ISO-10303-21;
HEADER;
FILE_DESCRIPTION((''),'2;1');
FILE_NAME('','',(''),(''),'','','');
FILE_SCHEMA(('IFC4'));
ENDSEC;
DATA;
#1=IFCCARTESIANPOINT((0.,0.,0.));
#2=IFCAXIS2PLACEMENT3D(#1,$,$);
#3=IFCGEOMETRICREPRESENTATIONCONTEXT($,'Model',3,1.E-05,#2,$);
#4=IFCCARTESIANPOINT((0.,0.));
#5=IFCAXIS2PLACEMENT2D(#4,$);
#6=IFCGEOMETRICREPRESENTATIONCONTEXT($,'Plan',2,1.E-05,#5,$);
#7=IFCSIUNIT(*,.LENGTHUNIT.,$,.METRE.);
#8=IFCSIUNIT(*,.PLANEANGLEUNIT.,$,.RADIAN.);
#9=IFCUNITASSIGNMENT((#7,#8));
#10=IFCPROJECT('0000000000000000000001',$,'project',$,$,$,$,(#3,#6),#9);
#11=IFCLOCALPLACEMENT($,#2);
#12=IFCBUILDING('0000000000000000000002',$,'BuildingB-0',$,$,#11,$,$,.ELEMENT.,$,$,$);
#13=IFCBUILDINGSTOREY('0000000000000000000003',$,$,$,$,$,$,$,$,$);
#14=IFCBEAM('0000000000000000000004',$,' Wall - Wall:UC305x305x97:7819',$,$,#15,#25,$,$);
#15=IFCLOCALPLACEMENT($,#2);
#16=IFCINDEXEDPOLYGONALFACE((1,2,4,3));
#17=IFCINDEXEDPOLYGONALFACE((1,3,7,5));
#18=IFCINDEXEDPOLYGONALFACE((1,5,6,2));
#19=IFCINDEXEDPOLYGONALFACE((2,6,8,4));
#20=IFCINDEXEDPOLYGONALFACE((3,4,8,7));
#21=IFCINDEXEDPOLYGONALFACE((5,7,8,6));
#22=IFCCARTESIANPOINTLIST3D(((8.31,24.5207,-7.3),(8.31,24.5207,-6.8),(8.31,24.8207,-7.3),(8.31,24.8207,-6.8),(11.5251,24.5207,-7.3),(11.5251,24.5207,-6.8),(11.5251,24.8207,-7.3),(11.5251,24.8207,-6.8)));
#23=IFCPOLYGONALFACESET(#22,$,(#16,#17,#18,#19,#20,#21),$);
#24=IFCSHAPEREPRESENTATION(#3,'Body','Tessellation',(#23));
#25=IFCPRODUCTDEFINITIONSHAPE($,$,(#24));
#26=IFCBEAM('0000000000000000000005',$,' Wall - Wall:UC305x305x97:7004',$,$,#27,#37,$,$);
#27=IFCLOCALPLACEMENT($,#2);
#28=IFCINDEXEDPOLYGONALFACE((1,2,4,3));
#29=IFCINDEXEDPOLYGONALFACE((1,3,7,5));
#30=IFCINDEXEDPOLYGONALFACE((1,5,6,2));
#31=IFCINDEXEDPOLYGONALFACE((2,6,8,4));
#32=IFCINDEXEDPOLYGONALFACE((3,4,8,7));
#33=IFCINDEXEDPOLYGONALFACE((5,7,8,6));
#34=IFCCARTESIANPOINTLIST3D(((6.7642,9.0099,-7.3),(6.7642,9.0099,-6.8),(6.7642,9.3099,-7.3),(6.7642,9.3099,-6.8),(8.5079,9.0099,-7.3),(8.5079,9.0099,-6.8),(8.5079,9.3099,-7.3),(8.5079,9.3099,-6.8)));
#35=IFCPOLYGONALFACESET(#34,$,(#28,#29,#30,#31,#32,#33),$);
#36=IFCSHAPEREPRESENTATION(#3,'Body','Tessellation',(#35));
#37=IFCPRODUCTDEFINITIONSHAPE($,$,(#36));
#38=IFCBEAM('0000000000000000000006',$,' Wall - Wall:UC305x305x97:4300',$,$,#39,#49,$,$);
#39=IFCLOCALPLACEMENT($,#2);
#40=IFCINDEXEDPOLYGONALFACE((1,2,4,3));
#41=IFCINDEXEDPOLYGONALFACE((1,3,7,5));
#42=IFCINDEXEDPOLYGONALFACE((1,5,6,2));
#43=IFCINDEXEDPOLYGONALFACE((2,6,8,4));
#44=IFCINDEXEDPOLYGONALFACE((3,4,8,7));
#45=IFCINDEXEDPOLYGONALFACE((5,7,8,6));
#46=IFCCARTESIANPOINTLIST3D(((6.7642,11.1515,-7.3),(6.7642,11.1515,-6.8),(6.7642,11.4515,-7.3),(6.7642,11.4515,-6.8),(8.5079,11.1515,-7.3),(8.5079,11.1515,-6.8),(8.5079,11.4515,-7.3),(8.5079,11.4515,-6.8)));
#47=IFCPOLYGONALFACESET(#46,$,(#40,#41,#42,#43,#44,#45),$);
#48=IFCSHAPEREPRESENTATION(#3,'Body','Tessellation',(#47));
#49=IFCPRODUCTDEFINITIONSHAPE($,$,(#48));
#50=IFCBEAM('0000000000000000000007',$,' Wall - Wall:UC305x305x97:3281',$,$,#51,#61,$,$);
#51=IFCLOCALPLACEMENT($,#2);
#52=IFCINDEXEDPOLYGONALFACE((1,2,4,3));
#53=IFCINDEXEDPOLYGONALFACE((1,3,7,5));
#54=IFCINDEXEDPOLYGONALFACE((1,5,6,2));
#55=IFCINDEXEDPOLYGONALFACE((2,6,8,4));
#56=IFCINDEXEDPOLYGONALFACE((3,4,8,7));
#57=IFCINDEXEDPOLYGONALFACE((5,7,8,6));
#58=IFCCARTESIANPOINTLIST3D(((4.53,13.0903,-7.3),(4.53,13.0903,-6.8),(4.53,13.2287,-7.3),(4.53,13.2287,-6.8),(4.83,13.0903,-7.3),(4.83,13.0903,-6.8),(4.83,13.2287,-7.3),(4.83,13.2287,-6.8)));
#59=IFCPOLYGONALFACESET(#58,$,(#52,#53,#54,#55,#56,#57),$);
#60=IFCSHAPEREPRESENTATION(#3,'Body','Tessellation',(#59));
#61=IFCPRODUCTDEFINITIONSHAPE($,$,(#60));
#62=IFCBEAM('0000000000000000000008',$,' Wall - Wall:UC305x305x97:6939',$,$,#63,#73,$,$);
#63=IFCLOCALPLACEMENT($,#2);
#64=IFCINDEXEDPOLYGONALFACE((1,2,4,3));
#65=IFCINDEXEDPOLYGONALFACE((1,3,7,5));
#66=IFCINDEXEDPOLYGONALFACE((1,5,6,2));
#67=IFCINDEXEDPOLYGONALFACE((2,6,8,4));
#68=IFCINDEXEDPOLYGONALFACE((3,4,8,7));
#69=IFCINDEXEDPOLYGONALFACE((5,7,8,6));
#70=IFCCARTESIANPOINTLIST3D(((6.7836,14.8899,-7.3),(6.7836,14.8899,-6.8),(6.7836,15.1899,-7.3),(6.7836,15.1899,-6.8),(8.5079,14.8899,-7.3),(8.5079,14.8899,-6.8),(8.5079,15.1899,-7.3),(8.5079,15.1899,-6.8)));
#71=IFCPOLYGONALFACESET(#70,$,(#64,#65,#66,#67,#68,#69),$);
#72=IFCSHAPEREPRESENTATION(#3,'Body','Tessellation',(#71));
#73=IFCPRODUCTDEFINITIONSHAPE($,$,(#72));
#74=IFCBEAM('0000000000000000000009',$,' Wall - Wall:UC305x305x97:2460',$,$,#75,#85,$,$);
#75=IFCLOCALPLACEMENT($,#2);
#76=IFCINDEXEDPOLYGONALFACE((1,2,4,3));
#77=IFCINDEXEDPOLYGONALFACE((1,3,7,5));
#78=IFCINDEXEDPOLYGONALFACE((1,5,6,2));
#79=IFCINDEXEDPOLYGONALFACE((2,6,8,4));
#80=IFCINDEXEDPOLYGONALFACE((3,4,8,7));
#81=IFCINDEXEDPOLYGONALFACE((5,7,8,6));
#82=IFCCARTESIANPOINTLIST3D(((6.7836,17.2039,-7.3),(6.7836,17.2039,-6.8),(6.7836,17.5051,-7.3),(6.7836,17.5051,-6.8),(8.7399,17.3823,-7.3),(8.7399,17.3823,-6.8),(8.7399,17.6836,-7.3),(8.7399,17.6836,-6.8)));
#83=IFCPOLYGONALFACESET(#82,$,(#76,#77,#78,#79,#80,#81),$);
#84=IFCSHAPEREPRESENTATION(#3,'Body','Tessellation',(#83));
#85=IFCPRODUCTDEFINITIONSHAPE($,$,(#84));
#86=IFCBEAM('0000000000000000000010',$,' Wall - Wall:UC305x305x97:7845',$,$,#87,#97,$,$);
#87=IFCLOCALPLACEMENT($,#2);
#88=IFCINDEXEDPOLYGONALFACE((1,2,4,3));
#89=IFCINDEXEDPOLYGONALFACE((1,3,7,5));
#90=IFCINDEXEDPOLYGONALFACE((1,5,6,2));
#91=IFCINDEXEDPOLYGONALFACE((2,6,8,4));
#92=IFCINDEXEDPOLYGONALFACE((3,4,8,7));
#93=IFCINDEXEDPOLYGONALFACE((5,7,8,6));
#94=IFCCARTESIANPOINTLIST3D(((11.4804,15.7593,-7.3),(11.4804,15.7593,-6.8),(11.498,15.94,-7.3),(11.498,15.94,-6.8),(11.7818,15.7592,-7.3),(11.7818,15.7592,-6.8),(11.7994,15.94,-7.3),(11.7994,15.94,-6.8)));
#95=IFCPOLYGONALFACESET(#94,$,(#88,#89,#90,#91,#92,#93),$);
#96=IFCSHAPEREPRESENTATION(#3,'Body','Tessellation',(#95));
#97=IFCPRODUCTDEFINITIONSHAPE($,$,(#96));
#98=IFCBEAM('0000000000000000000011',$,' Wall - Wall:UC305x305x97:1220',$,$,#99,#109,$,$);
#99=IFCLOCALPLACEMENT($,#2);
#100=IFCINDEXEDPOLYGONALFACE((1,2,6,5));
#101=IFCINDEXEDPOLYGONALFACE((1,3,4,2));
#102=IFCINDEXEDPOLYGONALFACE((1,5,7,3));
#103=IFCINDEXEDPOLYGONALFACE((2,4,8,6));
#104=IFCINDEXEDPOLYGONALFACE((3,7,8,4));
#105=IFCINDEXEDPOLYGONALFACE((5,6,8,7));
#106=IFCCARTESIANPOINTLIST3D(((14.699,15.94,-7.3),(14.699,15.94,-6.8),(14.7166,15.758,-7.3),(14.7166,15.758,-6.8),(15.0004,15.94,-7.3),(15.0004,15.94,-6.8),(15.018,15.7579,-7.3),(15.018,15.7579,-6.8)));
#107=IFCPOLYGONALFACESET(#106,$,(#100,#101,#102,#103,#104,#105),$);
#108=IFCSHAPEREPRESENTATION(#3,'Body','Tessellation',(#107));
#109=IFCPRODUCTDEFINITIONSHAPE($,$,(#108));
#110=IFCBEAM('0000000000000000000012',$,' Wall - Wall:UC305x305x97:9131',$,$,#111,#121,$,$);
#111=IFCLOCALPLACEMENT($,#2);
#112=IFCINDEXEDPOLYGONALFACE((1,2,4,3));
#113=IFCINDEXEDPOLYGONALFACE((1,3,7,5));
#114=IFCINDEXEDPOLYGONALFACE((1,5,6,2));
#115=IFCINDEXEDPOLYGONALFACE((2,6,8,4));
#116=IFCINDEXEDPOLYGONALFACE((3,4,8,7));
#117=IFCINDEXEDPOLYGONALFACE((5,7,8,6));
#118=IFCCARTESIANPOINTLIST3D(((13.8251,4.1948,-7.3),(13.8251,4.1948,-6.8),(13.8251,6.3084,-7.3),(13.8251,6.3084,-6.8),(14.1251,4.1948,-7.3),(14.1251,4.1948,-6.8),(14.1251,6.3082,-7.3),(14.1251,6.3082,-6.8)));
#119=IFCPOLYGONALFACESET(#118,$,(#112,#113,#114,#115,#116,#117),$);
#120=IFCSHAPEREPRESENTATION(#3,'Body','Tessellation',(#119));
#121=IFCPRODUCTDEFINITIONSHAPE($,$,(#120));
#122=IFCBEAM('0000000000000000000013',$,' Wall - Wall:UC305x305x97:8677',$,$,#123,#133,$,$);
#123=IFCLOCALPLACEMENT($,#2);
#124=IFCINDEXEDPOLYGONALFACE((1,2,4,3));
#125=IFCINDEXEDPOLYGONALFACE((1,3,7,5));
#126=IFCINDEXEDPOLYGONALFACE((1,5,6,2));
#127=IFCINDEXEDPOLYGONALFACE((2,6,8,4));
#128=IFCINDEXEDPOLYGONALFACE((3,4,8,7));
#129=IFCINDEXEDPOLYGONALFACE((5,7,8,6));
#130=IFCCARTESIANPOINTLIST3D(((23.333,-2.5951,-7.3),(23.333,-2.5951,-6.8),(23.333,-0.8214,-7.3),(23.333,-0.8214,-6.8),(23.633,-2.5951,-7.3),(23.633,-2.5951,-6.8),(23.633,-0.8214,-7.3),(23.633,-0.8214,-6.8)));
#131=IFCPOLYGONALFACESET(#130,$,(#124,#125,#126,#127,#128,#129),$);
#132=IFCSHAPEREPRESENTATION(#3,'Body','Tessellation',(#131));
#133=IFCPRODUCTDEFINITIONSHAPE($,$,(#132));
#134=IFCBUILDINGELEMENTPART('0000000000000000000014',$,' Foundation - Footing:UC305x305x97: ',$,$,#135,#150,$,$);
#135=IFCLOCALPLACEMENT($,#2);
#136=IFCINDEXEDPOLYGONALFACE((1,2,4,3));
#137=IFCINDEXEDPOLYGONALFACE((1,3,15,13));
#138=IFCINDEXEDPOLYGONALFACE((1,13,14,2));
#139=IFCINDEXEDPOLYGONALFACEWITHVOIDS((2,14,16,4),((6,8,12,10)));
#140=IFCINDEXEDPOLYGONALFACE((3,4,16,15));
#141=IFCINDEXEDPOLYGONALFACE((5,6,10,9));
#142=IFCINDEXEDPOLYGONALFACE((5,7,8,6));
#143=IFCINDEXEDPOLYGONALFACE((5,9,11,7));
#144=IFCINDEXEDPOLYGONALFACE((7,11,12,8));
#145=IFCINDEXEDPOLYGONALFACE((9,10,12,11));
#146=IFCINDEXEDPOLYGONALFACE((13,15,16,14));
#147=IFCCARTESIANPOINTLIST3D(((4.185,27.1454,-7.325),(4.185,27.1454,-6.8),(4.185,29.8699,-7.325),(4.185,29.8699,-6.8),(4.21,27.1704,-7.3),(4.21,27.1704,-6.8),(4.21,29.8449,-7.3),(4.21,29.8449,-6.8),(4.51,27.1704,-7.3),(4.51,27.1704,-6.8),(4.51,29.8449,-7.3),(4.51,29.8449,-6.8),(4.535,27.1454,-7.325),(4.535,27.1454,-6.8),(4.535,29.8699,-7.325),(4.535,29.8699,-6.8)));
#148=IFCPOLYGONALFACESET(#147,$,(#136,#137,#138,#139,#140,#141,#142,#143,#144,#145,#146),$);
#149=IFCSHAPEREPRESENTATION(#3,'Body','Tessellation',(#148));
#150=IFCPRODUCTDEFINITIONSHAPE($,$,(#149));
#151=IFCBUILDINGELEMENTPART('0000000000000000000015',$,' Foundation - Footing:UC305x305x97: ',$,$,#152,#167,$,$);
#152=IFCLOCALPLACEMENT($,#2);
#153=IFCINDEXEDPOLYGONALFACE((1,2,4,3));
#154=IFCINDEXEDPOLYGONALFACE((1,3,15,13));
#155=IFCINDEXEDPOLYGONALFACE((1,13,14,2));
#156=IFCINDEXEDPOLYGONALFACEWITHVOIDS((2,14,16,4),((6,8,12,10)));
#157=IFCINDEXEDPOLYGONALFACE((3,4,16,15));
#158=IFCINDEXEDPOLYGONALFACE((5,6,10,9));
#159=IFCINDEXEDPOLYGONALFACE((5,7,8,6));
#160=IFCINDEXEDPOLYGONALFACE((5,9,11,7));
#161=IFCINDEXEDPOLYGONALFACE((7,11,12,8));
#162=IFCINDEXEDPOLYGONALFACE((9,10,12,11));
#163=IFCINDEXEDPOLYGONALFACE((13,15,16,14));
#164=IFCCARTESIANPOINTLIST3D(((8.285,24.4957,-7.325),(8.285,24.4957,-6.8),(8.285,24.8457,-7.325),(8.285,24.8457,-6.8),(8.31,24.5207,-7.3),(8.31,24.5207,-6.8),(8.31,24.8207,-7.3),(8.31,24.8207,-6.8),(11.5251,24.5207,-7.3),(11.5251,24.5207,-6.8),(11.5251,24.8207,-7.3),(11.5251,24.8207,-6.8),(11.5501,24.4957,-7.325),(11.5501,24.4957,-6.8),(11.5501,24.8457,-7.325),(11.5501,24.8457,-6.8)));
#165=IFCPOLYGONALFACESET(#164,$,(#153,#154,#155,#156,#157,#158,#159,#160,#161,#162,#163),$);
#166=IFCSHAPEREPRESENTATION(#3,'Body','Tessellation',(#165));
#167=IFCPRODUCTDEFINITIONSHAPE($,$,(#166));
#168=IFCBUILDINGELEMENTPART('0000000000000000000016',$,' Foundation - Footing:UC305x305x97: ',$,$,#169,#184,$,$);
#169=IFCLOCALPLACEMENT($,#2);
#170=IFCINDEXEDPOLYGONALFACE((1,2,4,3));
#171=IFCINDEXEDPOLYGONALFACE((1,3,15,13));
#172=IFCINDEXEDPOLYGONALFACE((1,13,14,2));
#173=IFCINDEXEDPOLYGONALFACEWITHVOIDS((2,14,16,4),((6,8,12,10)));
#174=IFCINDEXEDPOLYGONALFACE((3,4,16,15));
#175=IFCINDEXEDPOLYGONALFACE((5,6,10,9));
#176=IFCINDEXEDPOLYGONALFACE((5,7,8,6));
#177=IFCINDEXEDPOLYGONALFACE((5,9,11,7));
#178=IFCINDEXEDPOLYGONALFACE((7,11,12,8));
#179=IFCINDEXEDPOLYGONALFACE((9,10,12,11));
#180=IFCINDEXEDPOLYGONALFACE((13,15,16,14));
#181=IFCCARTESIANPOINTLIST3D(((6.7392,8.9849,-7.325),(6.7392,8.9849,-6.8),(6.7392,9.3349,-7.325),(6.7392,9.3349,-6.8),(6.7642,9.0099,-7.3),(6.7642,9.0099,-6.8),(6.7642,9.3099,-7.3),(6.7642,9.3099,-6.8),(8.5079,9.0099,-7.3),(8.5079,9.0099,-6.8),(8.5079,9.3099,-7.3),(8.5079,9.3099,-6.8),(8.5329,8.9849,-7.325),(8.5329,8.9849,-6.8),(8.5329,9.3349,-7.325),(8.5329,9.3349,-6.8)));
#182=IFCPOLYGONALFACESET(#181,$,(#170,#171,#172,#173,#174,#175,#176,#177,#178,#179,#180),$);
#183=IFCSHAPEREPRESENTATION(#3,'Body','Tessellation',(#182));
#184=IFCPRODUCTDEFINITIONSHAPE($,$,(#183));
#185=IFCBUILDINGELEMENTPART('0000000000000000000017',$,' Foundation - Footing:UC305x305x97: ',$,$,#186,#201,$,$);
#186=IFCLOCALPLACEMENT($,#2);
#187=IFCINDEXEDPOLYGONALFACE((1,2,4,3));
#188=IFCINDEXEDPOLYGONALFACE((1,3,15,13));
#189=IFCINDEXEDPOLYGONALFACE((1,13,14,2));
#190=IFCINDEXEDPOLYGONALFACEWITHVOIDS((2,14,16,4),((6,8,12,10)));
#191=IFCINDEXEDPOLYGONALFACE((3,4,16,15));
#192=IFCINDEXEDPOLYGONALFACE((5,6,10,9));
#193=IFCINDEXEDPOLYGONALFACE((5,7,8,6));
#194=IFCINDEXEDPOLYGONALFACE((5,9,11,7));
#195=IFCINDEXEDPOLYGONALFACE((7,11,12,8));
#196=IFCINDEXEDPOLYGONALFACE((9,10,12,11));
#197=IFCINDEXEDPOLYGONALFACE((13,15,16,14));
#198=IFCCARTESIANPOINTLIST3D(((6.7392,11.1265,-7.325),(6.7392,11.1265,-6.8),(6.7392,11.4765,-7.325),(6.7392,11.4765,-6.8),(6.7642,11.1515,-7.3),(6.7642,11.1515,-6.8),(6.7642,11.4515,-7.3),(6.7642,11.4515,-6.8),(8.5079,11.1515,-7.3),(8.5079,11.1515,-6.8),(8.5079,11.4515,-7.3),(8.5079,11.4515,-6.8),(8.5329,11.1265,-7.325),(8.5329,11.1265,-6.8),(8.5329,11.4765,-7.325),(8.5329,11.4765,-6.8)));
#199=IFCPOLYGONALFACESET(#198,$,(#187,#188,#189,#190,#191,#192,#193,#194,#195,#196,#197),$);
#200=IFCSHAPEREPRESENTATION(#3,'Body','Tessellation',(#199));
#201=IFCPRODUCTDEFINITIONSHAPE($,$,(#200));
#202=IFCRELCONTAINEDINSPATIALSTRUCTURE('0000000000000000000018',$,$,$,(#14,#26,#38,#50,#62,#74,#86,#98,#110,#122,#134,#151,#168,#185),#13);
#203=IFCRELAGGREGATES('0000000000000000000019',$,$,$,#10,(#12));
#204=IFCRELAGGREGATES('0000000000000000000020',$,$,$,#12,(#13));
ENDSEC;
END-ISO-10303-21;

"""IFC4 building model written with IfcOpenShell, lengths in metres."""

from ifc_helpers import new_model, si_unit, origin, origin_2d, place, context, project, spatial, polyline, outline, extrude, element, save


model = new_model("IFC4")

# Units and contexts
model_context = context("Model", 3, precision=1e-05, world=origin())
plan_context = context("Plan", 2, precision=1e-05, world=origin_2d())
ifc_project = project(units=[si_unit("LENGTHUNIT", "METRE"), si_unit("PLANEANGLEUNIT", "RADIAN")], contexts=[model_context, plan_context])

# Building, storey
building_placement = place(None, origin())
building = spatial("IfcBuilding", under=ifc_project, at=building_placement, Name="BuildingB-0", CompositionType="ELEMENT")
storey = spatial("IfcBuildingStorey", under=building)

# Beams
element("IfcBeam", 1, inside=storey, Name=" Wall - Wall:UC305x305x97:7819", context=model_context, shape_type="SweptSolid", body=[
    extrude(outline(polyline([(8.31, 24.5207, -7.3), (8.31, 24.8207, -7.3), (11.5251, 24.8207, -7.3), (11.5251, 24.5207, -7.3), (8.31, 24.5207, -7.3)])), None, (0.0, 0.0, 1.0), 0.5),
])
element("IfcBeam", 2, inside=storey, Name=" Wall - Wall:UC305x305x97:7004", context=model_context, shape_type="SweptSolid", body=[
    extrude(outline(polyline([(6.7642, 9.0099, -7.3), (6.7642, 9.3099, -7.3), (8.5079, 9.3099, -7.3), (8.5079, 9.0099, -7.3), (6.7642, 9.0099, -7.3)])), None, (0.0, 0.0, 1.0), 0.5),
])
element("IfcBeam", 3, inside=storey, Name=" Wall - Wall:UC305x305x97:4300", context=model_context, shape_type="SweptSolid", body=[
    extrude(outline(polyline([(6.7642, 11.1515, -7.3), (6.7642, 11.4515, -7.3), (8.5079, 11.4515, -7.3), (8.5079, 11.1515, -7.3), (6.7642, 11.1515, -7.3)])), None, (0.0, 0.0, 1.0), 0.5),
])
element("IfcBeam", 4, inside=storey, Name=" Wall - Wall:UC305x305x97:3281", context=model_context, shape_type="SweptSolid", body=[
    extrude(outline(polyline([(4.53, 13.0903, -7.3), (4.53, 13.2287, -7.3), (4.83, 13.2287, -7.3), (4.83, 13.0903, -7.3), (4.53, 13.0903, -7.3)])), None, (0.0, 0.0, 1.0), 0.5),
])
element("IfcBeam", 5, inside=storey, Name=" Wall - Wall:UC305x305x97:6939", context=model_context, shape_type="SweptSolid", body=[
    extrude(outline(polyline([(6.7836, 14.8899, -7.3), (6.7836, 15.1899, -7.3), (8.5079, 15.1899, -7.3), (8.5079, 14.8899, -7.3), (6.7836, 14.8899, -7.3)])), None, (0.0, 0.0, 1.0), 0.5),
])
element("IfcBeam", 6, inside=storey, Name=" Wall - Wall:UC305x305x97:2460", context=model_context, shape_type="SweptSolid", body=[
    extrude(outline(polyline([(6.7836, 17.2039, -7.3), (6.7836, 17.5051, -7.3), (8.7399, 17.6836, -7.3), (8.7399, 17.3823, -7.3), (6.7836, 17.2039, -7.3)])), None, (0.0, 0.0, 1.0), 0.5),
])
element("IfcBeam", 7, inside=storey, Name=" Wall - Wall:UC305x305x97:7845", context=model_context, shape_type="SweptSolid", body=[
    extrude(outline(polyline([(11.4804, 15.7593, -7.3), (11.498, 15.94, -7.3), (11.7994, 15.94, -7.3), (11.7818, 15.7592, -7.3), (11.4804, 15.7593, -7.3)])), None, (0.0, 0.0, 1.0), 0.5),
])
element("IfcBeam", 8, inside=storey, Name=" Wall - Wall:UC305x305x97:1220", context=model_context, shape_type="SweptSolid", body=[
    extrude(outline(polyline([(14.7166, 15.758, -7.3), (14.699, 15.94, -7.3), (15.0004, 15.94, -7.3), (15.018, 15.7579, -7.3), (14.7166, 15.758, -7.3)])), None, (0.0, 0.0, 1.0), 0.5),
])
element("IfcBeam", 9, inside=storey, Name=" Wall - Wall:UC305x305x97:9131", context=model_context, shape_type="SweptSolid", body=[
    extrude(outline(polyline([(13.8251, 4.1948, -7.3), (13.8251, 6.3084, -7.3), (14.1251, 6.3082, -7.3), (14.1251, 4.1948, -7.3), (13.8251, 4.1948, -7.3)])), None, (0.0, 0.0, 1.0), 0.5),
])
element("IfcBeam", 10, inside=storey, Name=" Wall - Wall:UC305x305x97:8677", context=model_context, shape_type="SweptSolid", body=[
    extrude(outline(polyline([(23.333, -2.5951, -7.3), (23.333, -0.8214, -7.3), (23.633, -0.8214, -7.3), (23.633, -2.5951, -7.3), (23.333, -2.5951, -7.3)])), None, (0.0, 0.0, 1.0), 0.5),
])

# Building element parts, openings
building_element_part_1 = element("IfcBuildingElementPart", 11, inside=storey, Name=" Foundation - Footing:UC305x305x97: ", context=model_context, shape_type="SweptSolid", body=[
    extrude(outline(polyline([(4.535, 27.1454, -7.325), (4.185, 27.1454, -7.325), (4.185, 29.8699, -7.325), (4.535, 29.8699, -7.325), (4.535, 27.1454, -7.325)])), None, (0.0, 0.0, 1.0), 0.525),
])
element("IfcOpeningElement", 12, inside=storey, cuts=building_element_part_1, context=model_context, shape_type="SweptSolid", body=[
    extrude(outline(polyline([(4.51, 27.1704, -7.3), (4.21, 27.1704, -7.3), (4.21, 29.8449, -7.3), (4.51, 29.8449, -7.3), (4.51, 27.1704, -7.3)])), None, (0.0, 0.0, 1.0), 0.5),
])
building_element_part_2 = element("IfcBuildingElementPart", 13, inside=storey, Name=" Foundation - Footing:UC305x305x97: ", context=model_context, shape_type="SweptSolid", body=[
    extrude(outline(polyline([(8.285, 24.4957, -7.325), (8.285, 24.8457, -7.325), (11.5501, 24.8457, -7.325), (11.5501, 24.4957, -7.325), (8.285, 24.4957, -7.325)])), None, (0.0, 0.0, 1.0), 0.525),
])
element("IfcOpeningElement", 14, inside=storey, cuts=building_element_part_2, context=model_context, shape_type="SweptSolid", body=[
    extrude(outline(polyline([(8.31, 24.5207, -7.3), (8.31, 24.8207, -7.3), (11.5251, 24.8207, -7.3), (11.5251, 24.5207, -7.3), (8.31, 24.5207, -7.3)])), None, (0.0, 0.0, 1.0), 0.5),
])
building_element_part_3 = element("IfcBuildingElementPart", 15, inside=storey, Name=" Foundation - Footing:UC305x305x97: ", context=model_context, shape_type="SweptSolid", body=[
    extrude(outline(polyline([(6.7392, 8.9849, -7.325), (6.7392, 9.3349, -7.325), (8.5329, 9.3349, -7.325), (8.5329, 8.9849, -7.325), (6.7392, 8.9849, -7.325)])), None, (0.0, 0.0, 1.0), 0.525),
])
element("IfcOpeningElement", 16, inside=storey, cuts=building_element_part_3, context=model_context, shape_type="SweptSolid", body=[
    extrude(outline(polyline([(6.7642, 9.0099, -7.3), (6.7642, 9.3099, -7.3), (8.5079, 9.3099, -7.3), (8.5079, 9.0099, -7.3), (6.7642, 9.0099, -7.3)])), None, (0.0, 0.0, 1.0), 0.5),
])
building_element_part_4 = element("IfcBuildingElementPart", 17, inside=storey, Name=" Foundation - Footing:UC305x305x97: ", context=model_context, shape_type="SweptSolid", body=[
    extrude(outline(polyline([(6.7392, 11.1265, -7.325), (6.7392, 11.4765, -7.325), (8.5329, 11.4765, -7.325), (8.5329, 11.1265, -7.325), (6.7392, 11.1265, -7.325)])), None, (0.0, 0.0, 1.0), 0.525),
])
element("IfcOpeningElement", 18, inside=storey, cuts=building_element_part_4, context=model_context, shape_type="SweptSolid", body=[
    extrude(outline(polyline([(6.7642, 11.1515, -7.3), (6.7642, 11.4515, -7.3), (8.5079, 11.4515, -7.3), (8.5079, 11.1515, -7.3), (6.7642, 11.1515, -7.3)])), None, (0.0, 0.0, 1.0), 0.5),
])

save(model, "model.ifc")
